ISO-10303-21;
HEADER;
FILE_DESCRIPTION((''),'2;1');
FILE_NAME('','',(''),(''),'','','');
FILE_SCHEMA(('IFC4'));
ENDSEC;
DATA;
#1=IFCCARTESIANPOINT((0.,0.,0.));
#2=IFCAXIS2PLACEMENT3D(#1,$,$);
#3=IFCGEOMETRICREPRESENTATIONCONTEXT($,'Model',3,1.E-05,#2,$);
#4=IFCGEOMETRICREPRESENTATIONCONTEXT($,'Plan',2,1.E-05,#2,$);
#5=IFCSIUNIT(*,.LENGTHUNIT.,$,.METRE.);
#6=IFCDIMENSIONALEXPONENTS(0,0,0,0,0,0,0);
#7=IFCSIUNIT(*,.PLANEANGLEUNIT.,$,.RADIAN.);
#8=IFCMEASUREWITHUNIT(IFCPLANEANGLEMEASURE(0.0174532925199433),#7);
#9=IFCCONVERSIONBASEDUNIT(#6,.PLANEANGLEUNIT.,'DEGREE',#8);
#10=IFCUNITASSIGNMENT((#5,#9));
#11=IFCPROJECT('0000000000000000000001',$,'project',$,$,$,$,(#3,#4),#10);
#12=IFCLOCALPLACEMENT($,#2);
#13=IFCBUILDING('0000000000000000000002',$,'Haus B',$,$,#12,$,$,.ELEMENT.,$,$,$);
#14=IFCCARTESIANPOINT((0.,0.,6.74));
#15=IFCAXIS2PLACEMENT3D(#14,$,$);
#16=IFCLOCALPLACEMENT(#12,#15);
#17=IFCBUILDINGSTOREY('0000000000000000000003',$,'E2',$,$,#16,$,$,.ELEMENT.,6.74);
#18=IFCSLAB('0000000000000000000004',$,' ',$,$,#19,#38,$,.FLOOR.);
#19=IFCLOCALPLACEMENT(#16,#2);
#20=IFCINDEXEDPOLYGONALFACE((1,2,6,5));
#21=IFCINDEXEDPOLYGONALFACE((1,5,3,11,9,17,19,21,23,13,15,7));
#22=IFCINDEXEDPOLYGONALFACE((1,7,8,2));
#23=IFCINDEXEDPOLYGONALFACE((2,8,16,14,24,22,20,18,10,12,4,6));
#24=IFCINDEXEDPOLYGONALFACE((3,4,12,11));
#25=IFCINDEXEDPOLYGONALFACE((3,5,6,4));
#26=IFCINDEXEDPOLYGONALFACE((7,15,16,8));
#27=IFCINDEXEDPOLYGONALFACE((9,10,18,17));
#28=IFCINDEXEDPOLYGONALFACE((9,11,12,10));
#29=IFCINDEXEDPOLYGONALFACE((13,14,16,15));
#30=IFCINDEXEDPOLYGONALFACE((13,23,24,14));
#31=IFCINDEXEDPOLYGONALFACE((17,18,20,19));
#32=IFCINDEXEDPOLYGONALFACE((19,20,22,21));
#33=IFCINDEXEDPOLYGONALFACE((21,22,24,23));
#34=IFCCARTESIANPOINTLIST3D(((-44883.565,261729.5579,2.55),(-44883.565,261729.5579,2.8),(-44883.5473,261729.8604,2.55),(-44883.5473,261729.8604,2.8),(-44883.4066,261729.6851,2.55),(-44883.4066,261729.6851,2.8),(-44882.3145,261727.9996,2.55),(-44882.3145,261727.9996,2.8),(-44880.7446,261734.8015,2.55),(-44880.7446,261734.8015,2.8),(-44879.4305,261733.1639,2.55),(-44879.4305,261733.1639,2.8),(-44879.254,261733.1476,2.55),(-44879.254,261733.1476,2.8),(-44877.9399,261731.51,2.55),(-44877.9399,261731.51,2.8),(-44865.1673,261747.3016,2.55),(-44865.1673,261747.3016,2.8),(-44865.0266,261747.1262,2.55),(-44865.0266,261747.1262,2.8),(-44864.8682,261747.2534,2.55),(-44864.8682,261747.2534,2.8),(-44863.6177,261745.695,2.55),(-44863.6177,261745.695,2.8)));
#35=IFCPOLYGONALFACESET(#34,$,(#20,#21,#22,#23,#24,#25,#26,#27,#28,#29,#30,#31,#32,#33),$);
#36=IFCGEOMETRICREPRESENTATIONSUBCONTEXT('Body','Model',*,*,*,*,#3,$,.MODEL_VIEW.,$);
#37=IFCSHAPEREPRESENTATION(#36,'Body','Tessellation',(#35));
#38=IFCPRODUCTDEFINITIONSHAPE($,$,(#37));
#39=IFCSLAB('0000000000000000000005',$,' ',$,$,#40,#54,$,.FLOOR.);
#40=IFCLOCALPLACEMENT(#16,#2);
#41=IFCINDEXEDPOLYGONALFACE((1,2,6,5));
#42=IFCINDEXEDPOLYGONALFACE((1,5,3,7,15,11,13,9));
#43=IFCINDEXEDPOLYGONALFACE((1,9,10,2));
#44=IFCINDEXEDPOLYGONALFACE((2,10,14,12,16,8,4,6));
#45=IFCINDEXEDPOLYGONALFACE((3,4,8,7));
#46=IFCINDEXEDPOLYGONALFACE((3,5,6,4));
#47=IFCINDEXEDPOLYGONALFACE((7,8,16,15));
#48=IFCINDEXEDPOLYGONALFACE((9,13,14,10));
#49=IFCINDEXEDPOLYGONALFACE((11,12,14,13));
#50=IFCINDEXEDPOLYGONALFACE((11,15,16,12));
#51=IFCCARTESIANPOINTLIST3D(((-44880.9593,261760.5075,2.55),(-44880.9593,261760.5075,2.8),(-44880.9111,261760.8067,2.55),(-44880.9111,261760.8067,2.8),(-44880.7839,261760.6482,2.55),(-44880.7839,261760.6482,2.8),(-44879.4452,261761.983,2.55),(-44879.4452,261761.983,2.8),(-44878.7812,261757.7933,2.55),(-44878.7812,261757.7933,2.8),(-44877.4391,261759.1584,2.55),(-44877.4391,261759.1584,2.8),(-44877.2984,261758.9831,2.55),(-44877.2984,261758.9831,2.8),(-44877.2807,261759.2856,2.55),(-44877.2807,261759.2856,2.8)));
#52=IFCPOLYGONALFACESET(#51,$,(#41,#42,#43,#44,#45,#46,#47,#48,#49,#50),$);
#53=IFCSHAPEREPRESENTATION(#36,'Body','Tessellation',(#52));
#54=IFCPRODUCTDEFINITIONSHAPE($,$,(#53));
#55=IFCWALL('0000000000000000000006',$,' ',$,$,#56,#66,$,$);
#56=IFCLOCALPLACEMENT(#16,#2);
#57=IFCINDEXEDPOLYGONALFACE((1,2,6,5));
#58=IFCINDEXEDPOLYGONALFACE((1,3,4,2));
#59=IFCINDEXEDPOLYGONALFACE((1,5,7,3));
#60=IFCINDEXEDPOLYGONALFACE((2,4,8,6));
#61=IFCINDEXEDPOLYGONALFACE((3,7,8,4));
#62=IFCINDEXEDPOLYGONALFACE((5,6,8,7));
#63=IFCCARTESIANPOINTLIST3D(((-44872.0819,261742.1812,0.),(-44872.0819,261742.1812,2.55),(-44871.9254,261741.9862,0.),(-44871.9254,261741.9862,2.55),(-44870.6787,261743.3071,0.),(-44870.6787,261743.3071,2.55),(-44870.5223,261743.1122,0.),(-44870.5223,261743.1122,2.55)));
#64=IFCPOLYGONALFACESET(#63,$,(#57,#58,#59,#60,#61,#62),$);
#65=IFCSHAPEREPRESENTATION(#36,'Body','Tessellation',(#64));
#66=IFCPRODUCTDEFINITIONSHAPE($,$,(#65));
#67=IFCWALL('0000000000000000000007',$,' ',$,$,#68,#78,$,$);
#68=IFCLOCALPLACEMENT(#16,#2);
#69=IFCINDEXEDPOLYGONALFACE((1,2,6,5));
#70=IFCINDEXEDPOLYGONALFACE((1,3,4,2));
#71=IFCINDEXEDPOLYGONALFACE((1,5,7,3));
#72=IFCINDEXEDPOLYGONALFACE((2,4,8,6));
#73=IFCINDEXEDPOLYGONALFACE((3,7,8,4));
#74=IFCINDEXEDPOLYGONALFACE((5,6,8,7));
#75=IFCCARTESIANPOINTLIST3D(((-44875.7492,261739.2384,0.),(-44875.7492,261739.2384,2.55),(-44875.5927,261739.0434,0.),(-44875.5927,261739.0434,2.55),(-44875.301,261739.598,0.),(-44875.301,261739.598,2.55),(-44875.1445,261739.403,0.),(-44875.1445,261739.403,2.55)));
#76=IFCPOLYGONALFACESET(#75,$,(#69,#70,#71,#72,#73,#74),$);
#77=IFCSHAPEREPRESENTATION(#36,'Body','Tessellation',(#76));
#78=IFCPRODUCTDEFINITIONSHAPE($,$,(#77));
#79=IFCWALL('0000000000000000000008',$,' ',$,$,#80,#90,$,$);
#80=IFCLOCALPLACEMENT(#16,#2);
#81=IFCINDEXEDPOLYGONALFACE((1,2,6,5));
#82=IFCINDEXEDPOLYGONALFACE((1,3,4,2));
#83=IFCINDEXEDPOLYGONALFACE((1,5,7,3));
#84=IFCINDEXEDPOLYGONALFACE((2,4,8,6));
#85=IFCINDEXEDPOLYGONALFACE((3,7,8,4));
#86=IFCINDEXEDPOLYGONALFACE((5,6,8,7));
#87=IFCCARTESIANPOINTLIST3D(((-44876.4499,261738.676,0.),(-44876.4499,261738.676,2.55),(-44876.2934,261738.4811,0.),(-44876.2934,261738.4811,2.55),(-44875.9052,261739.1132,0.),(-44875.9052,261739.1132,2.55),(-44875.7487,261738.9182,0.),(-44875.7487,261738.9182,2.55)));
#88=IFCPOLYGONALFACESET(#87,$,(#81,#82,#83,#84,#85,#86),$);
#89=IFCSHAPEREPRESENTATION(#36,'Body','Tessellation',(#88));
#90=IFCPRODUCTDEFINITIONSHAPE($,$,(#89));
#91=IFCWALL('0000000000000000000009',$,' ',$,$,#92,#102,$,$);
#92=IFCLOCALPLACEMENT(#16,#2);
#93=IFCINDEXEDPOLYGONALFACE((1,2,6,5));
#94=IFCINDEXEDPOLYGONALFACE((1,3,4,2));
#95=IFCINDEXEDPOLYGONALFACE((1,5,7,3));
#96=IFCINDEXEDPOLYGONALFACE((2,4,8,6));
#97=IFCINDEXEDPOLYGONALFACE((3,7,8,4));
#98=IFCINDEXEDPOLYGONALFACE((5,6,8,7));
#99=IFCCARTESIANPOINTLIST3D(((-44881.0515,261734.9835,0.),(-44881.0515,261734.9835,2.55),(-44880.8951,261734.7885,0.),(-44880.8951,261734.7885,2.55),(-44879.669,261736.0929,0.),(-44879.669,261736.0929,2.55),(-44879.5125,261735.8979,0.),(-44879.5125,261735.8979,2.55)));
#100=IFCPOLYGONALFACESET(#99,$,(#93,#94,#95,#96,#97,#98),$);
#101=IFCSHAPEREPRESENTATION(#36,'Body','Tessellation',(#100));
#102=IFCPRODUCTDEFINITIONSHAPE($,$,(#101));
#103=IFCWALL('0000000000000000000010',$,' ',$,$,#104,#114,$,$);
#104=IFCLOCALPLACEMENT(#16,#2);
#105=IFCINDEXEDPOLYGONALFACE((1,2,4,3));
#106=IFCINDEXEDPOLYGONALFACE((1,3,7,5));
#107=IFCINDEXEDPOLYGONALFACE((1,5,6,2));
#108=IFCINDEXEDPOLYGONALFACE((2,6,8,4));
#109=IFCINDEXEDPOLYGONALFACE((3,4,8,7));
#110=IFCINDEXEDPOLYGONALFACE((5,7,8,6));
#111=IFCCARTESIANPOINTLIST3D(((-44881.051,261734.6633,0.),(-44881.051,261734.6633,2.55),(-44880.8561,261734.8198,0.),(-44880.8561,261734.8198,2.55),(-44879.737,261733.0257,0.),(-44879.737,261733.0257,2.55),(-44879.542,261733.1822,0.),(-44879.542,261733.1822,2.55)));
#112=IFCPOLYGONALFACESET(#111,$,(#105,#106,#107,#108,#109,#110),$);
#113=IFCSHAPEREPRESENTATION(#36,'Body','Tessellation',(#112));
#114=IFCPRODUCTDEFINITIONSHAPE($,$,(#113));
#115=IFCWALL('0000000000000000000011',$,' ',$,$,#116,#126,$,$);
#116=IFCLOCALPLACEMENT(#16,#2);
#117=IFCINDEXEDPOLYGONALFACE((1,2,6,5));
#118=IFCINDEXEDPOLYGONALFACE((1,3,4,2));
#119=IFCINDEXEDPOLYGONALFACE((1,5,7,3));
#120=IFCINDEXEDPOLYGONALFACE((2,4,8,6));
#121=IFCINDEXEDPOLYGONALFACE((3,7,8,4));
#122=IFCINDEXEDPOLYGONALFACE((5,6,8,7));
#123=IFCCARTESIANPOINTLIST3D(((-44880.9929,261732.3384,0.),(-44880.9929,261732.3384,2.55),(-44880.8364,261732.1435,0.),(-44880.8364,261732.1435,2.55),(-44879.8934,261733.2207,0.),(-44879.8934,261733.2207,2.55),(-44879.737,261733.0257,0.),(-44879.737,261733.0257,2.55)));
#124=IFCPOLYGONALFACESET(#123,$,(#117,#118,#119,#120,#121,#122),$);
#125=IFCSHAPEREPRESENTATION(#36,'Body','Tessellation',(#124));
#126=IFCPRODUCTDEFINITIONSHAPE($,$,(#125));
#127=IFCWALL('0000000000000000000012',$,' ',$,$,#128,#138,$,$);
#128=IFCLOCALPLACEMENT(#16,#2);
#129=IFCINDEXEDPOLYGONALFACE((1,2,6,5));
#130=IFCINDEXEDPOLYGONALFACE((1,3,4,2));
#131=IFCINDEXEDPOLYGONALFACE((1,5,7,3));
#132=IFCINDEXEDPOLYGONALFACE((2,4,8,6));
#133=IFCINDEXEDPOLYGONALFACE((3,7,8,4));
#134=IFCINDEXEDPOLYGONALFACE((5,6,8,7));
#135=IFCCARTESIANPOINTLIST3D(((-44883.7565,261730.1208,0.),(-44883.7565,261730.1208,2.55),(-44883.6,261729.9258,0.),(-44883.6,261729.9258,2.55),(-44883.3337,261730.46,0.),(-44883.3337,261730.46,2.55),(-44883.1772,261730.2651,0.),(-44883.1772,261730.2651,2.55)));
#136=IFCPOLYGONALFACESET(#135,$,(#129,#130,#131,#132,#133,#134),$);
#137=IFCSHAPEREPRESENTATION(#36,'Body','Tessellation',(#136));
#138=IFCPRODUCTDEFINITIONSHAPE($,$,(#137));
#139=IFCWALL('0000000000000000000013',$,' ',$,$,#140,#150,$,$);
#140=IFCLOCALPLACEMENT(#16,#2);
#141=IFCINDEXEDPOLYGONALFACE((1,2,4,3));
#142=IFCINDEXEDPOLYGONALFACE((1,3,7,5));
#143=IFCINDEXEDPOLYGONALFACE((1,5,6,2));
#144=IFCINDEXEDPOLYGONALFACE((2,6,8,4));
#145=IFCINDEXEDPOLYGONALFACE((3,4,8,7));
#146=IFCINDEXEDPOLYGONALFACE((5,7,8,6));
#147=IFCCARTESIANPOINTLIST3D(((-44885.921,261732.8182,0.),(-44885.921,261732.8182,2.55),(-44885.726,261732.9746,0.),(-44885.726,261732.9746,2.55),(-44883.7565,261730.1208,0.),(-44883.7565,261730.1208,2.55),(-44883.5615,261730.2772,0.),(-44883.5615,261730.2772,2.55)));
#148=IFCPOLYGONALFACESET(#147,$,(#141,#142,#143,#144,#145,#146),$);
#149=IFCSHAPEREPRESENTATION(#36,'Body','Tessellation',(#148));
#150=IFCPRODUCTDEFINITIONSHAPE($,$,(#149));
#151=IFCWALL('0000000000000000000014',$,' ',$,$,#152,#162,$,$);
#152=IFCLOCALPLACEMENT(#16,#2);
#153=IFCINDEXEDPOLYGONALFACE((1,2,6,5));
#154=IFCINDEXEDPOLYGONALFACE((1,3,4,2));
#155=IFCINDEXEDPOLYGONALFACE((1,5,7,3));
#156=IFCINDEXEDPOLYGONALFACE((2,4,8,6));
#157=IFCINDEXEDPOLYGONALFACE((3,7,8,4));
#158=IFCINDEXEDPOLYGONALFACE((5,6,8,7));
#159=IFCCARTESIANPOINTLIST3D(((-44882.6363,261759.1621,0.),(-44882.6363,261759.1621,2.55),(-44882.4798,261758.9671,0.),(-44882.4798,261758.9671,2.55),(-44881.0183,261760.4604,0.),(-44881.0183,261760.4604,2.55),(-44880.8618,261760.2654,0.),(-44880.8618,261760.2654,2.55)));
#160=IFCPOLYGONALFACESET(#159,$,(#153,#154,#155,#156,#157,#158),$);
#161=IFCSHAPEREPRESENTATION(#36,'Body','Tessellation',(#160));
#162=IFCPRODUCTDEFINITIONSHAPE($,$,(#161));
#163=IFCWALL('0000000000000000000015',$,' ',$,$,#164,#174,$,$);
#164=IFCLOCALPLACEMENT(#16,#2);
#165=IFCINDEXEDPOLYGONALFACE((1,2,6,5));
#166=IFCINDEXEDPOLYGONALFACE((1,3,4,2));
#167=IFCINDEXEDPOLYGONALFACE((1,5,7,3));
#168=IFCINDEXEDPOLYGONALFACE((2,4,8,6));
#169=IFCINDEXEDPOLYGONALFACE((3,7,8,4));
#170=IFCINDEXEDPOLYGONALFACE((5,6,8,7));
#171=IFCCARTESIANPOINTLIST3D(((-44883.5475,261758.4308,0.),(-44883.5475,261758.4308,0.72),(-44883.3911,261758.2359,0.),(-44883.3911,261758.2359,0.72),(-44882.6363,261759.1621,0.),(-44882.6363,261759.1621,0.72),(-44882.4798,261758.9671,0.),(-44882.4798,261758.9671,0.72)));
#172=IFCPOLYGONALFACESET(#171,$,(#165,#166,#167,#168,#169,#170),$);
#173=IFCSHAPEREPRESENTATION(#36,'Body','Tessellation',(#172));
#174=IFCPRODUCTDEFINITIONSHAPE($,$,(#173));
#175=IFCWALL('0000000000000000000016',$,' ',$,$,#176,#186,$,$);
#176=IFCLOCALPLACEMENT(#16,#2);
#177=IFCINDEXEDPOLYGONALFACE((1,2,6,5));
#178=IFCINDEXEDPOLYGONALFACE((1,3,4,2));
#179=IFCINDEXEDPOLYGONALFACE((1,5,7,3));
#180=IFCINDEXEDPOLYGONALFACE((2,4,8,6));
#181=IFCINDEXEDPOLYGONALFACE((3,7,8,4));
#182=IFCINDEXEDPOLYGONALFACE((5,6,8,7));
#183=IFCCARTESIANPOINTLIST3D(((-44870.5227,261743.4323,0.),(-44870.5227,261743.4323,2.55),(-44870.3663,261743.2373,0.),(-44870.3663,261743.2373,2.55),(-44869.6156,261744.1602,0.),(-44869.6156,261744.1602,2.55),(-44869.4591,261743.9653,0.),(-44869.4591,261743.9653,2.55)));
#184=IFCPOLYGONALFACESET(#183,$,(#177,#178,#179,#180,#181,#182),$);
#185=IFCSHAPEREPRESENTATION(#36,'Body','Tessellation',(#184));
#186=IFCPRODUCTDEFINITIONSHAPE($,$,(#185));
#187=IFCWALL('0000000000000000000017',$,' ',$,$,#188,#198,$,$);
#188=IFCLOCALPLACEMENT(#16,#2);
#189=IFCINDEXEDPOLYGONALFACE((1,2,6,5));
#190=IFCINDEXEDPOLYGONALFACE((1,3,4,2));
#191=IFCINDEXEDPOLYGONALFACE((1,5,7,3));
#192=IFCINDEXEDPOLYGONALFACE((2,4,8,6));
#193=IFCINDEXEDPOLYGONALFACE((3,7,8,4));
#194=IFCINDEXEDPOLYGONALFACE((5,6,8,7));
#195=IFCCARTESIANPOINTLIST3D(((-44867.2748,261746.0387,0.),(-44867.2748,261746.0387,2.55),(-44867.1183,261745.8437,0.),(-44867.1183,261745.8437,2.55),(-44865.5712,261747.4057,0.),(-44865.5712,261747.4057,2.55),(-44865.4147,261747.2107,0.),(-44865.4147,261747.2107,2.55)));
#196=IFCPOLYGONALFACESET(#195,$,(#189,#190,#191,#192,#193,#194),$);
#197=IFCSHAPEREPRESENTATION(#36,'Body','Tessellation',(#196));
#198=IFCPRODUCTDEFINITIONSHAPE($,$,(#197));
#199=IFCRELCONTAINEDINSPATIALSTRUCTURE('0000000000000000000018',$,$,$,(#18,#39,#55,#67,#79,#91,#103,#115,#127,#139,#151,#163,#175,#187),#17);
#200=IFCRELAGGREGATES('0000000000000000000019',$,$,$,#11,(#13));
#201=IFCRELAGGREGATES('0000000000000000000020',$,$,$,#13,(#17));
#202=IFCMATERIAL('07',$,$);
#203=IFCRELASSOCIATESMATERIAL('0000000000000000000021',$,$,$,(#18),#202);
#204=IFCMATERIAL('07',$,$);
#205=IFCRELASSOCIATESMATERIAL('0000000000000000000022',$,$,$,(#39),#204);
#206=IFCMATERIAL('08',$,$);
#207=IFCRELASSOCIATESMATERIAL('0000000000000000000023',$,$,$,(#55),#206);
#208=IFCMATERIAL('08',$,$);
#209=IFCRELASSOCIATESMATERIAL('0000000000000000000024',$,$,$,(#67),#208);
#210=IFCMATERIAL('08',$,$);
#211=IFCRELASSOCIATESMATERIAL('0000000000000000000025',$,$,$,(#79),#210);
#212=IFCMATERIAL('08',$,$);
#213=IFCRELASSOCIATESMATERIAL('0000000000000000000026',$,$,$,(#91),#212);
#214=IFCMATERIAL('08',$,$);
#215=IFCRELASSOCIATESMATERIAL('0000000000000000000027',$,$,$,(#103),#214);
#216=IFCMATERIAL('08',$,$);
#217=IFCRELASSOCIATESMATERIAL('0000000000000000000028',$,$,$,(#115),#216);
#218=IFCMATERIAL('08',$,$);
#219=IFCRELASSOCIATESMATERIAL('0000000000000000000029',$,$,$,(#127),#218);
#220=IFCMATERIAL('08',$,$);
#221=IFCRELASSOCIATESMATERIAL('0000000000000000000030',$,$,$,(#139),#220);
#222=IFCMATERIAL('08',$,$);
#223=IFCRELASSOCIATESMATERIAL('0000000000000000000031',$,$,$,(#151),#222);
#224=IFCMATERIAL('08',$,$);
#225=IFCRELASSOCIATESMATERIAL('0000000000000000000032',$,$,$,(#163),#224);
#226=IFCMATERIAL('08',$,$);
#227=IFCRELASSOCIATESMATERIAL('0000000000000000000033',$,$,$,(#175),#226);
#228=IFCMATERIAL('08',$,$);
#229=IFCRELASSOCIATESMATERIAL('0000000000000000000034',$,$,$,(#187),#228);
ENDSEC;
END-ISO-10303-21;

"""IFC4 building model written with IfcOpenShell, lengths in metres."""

from ifc_helpers import new_model, entity, si_unit, converted_unit, frame, frame_2d, origin, origin_with_axes, place, context, subcontext, project, spatial, polyline, rectangle, outline, extrude, material, element, save


model = new_model("IFC4")

# Units and contexts
model_context = context("Model", 3, precision=1e-05, world=origin())
plan_context = context("Plan", 2, precision=1e-05, world=origin())
body_context = subcontext(model_context, "Body", "Model", "MODEL_VIEW")
ifc_project = project(units=[si_unit("LENGTHUNIT", "METRE"), converted_unit("PLANEANGLEUNIT", "DEGREE", entity("IfcPlaneAngleMeasure", 0.0174532925199433), si_unit("PLANEANGLEUNIT", "RADIAN"), dimensions=[0, 0, 0, 0, 0, 0, 0])], contexts=[model_context, plan_context])

# Building, storey
building_placement = place(None, origin())
building = spatial("IfcBuilding", under=ifc_project, at=building_placement, Name="Haus B", CompositionType="ELEMENT")
storey_placement = place(building_placement, frame((0.0, 0.0, 6.74)))
storey = spatial("IfcBuildingStorey", under=building, at=storey_placement, Name="E2", CompositionType="ELEMENT", Elevation=6.74)

# Slabs
ifc_material_1 = material(Name="07")
slab_1_placement = place(storey_placement, frame((-44883.565, 261727.9996, 2.55)))
element("IfcSlab", 1, at=slab_1_placement, inside=storey, material=ifc_material_1, Name=" ", PredefinedType="FLOOR", context=body_context, shape_type="SweptSolid", body=[
    extrude(outline(polyline([(18.3977, 19.302), (2.8205, 6.8019), (4.1345, 5.1643), (0.0178, 1.8608), (0.1585, 1.6855), (0.0, 1.5584), (1.2505, 0.0), (5.6251, 3.5104), (4.311, 5.148), (19.9474, 17.6955), (18.6969, 19.2538), (18.5384, 19.1266), (18.3977, 19.302)])), origin_with_axes(), (0.0, 0.0, 1.0), 0.25),
])
ifc_material_2 = material(Name="07")
slab_2_placement = place(storey_placement, frame((-44880.9593, 261757.7933, 2.55)))
element("IfcSlab", 2, at=slab_2_placement, inside=storey, material=ifc_material_2, Name=" ", PredefinedType="FLOOR", context=body_context, shape_type="SweptSolid", body=[
    extrude(outline(polyline([(0.0, 2.7142), (2.1781, 0.0), (3.6608, 1.1898), (3.5201, 1.3652), (3.6786, 1.4923), (1.5141, 4.1897), (0.0482, 3.0134), (0.1753, 2.8549), (0.0, 2.7142)])), origin_with_axes(), (0.0, 0.0, 1.0), 0.25),
])

# Walls
ifc_material_3 = material(Name="08")
wall_1_placement = place(storey_placement, frame((-44870.6787, 261743.3071, 0.0), z_axis=(0.0, 0.0, 1.0), x_axis=(-0.779935, -0.625861, 0.0)))
element("IfcWall", 3, at=wall_1_placement, inside=storey, material=ifc_material_3, Name=" ", context=body_context, shape_type="SweptSolid", body=[
    extrude(rectangle(XDim=1.7991, YDim=0.25, at=frame_2d((0.8995, 0.125), x_axis=(1.0, 0.0))), origin_with_axes(), (0.0, 0.0, 1.0), 2.55),
])
ifc_material_4 = material(Name="08")
wall_2_placement = place(storey_placement, frame((-44875.301, 261739.598, 0.0), z_axis=(0.0, 0.0, 1.0), x_axis=(-0.779935, -0.625861, 0.0)))
element("IfcWall", 4, at=wall_2_placement, inside=storey, material=ifc_material_4, Name=" ", context=body_context, shape_type="SweptSolid", body=[
    extrude(rectangle(XDim=0.5747, YDim=0.25, at=frame_2d((0.2873, 0.125), x_axis=(1.0, 0.0))), origin_with_axes(), (0.0, 0.0, 1.0), 2.55),
])
ifc_material_5 = material(Name="08")
wall_3_placement = place(storey_placement, frame((-44875.9052, 261739.1132, 0.0), z_axis=(0.0, 0.0, 1.0), x_axis=(-0.779935, -0.625861, 0.0)))
element("IfcWall", 5, at=wall_3_placement, inside=storey, material=ifc_material_5, Name=" ", context=body_context, shape_type="SweptSolid", body=[
    extrude(rectangle(XDim=0.6985, YDim=0.25, at=frame_2d((0.3492, 0.125), x_axis=(1.0, 0.0))), origin_with_axes(), (0.0, 0.0, 1.0), 2.55),
])
ifc_material_6 = material(Name="08")
wall_4_placement = place(storey_placement, frame((-44879.669, 261736.0929, 0.0), z_axis=(0.0, 0.0, 1.0), x_axis=(-0.779935, -0.625861, 0.0)))
element("IfcWall", 6, at=wall_4_placement, inside=storey, material=ifc_material_6, Name=" ", context=body_context, shape_type="SweptSolid", body=[
    extrude(rectangle(XDim=1.7727, YDim=0.25, at=frame_2d((0.8863, 0.125), x_axis=(1.0, 0.0))), origin_with_axes(), (0.0, 0.0, 1.0), 2.55),
])
ifc_material_7 = material(Name="08")
wall_5_placement = place(storey_placement, frame((-44881.051, 261734.6633, 0.0), z_axis=(0.0, 0.0, 1.0), x_axis=(0.625861, -0.779935, 0.0)))
element("IfcWall", 7, at=wall_5_placement, inside=storey, material=ifc_material_7, Name=" ", context=body_context, shape_type="SweptSolid", body=[
    extrude(rectangle(XDim=2.0997, YDim=0.25, at=frame_2d((1.0498, 0.125), x_axis=(1.0, 0.0))), origin_with_axes(), (0.0, 0.0, 1.0), 2.55),
])
ifc_material_8 = material(Name="08")
wall_6_placement = place(storey_placement, frame((-44879.8934, 261733.2207, 0.0), z_axis=(0.0, 0.0, 1.0), x_axis=(-0.779935, -0.625861, 0.0)))
element("IfcWall", 8, at=wall_6_placement, inside=storey, material=ifc_material_8, Name=" ", context=body_context, shape_type="SweptSolid", body=[
    extrude(rectangle(XDim=1.4096, YDim=0.25, at=frame_2d((0.7048, 0.125), x_axis=(1.0, 0.0))), origin_with_axes(), (0.0, 0.0, 1.0), 2.55),
])
ifc_material_9 = material(Name="08")
wall_7_placement = place(storey_placement, frame((-44883.3337, 261730.46, 0.0), z_axis=(0.0, 0.0, 1.0), x_axis=(-0.779935, -0.625861, 0.0)))
element("IfcWall", 9, at=wall_7_placement, inside=storey, material=ifc_material_9, Name=" ", context=body_context, shape_type="SweptSolid", body=[
    extrude(rectangle(XDim=0.5421, YDim=0.25, at=frame_2d((0.271, 0.125), x_axis=(1.0, 0.0))), origin_with_axes(), (0.0, 0.0, 1.0), 2.55),
])
ifc_material_10 = material(Name="08")
wall_8_placement = place(storey_placement, frame((-44883.5615, 261730.2772, 0.0), z_axis=(0.0, 0.0, 1.0), x_axis=(-0.625861, 0.779935, 0.0)))
element("IfcWall", 10, at=wall_8_placement, inside=storey, material=ifc_material_10, Name=" ", context=body_context, shape_type="SweptSolid", body=[
    extrude(rectangle(XDim=3.4585, YDim=0.25, at=frame_2d((1.7292, 0.125), x_axis=(1.0, 0.0))), origin_with_axes(), (0.0, 0.0, 1.0), 2.55),
])
ifc_material_11 = material(Name="08")
wall_9_placement = place(storey_placement, frame((-44882.4798, 261758.9671, 0.0), z_axis=(0.0, 0.0, 1.0), x_axis=(0.779935, 0.625861, 0.0)))
element("IfcWall", 11, at=wall_9_placement, inside=storey, material=ifc_material_11, Name=" ", context=body_context, shape_type="SweptSolid", body=[
    extrude(rectangle(XDim=2.0745, YDim=0.25, at=frame_2d((1.0372, 0.125), x_axis=(1.0, 0.0))), origin_with_axes(), (0.0, 0.0, 1.0), 2.55),
])
ifc_material_12 = material(Name="08")
wall_10_placement = place(storey_placement, frame((-44883.3911, 261758.2359, 0.0), z_axis=(0.0, 0.0, 1.0), x_axis=(0.779935, 0.625861, 0.0)))
element("IfcWall", 12, at=wall_10_placement, inside=storey, material=ifc_material_12, Name=" ", context=body_context, shape_type="SweptSolid", body=[
    extrude(rectangle(XDim=1.1684, YDim=0.25, at=frame_2d((0.5842, 0.125), x_axis=(1.0, 0.0))), origin_with_axes(), (0.0, 0.0, 1.0), 0.72),
])
ifc_material_13 = material(Name="08")
wall_11_placement = place(storey_placement, frame((-44869.6156, 261744.1602, 0.0), z_axis=(0.0, 0.0, 1.0), x_axis=(-0.779935, -0.625861, 0.0)))
element("IfcWall", 13, at=wall_11_placement, inside=storey, material=ifc_material_13, Name=" ", context=body_context, shape_type="SweptSolid", body=[
    extrude(rectangle(XDim=1.1631, YDim=0.25, at=frame_2d((0.5815, 0.125), x_axis=(1.0, 0.0))), origin_with_axes(), (0.0, 0.0, 1.0), 2.55),
])
ifc_material_14 = material(Name="08")
wall_12_placement = place(storey_placement, frame((-44865.5712, 261747.4057, 0.0), z_axis=(0.0, 0.0, 1.0), x_axis=(-0.779935, -0.625861, 0.0)))
element("IfcWall", 14, at=wall_12_placement, inside=storey, material=ifc_material_14, Name=" ", context=body_context, shape_type="SweptSolid", body=[
    extrude(rectangle(XDim=2.1843, YDim=0.25, at=frame_2d((1.0922, 0.125), x_axis=(1.0, 0.0))), origin_with_axes(), (0.0, 0.0, 1.0), 2.55),
])

save(model, "model.ifc")
